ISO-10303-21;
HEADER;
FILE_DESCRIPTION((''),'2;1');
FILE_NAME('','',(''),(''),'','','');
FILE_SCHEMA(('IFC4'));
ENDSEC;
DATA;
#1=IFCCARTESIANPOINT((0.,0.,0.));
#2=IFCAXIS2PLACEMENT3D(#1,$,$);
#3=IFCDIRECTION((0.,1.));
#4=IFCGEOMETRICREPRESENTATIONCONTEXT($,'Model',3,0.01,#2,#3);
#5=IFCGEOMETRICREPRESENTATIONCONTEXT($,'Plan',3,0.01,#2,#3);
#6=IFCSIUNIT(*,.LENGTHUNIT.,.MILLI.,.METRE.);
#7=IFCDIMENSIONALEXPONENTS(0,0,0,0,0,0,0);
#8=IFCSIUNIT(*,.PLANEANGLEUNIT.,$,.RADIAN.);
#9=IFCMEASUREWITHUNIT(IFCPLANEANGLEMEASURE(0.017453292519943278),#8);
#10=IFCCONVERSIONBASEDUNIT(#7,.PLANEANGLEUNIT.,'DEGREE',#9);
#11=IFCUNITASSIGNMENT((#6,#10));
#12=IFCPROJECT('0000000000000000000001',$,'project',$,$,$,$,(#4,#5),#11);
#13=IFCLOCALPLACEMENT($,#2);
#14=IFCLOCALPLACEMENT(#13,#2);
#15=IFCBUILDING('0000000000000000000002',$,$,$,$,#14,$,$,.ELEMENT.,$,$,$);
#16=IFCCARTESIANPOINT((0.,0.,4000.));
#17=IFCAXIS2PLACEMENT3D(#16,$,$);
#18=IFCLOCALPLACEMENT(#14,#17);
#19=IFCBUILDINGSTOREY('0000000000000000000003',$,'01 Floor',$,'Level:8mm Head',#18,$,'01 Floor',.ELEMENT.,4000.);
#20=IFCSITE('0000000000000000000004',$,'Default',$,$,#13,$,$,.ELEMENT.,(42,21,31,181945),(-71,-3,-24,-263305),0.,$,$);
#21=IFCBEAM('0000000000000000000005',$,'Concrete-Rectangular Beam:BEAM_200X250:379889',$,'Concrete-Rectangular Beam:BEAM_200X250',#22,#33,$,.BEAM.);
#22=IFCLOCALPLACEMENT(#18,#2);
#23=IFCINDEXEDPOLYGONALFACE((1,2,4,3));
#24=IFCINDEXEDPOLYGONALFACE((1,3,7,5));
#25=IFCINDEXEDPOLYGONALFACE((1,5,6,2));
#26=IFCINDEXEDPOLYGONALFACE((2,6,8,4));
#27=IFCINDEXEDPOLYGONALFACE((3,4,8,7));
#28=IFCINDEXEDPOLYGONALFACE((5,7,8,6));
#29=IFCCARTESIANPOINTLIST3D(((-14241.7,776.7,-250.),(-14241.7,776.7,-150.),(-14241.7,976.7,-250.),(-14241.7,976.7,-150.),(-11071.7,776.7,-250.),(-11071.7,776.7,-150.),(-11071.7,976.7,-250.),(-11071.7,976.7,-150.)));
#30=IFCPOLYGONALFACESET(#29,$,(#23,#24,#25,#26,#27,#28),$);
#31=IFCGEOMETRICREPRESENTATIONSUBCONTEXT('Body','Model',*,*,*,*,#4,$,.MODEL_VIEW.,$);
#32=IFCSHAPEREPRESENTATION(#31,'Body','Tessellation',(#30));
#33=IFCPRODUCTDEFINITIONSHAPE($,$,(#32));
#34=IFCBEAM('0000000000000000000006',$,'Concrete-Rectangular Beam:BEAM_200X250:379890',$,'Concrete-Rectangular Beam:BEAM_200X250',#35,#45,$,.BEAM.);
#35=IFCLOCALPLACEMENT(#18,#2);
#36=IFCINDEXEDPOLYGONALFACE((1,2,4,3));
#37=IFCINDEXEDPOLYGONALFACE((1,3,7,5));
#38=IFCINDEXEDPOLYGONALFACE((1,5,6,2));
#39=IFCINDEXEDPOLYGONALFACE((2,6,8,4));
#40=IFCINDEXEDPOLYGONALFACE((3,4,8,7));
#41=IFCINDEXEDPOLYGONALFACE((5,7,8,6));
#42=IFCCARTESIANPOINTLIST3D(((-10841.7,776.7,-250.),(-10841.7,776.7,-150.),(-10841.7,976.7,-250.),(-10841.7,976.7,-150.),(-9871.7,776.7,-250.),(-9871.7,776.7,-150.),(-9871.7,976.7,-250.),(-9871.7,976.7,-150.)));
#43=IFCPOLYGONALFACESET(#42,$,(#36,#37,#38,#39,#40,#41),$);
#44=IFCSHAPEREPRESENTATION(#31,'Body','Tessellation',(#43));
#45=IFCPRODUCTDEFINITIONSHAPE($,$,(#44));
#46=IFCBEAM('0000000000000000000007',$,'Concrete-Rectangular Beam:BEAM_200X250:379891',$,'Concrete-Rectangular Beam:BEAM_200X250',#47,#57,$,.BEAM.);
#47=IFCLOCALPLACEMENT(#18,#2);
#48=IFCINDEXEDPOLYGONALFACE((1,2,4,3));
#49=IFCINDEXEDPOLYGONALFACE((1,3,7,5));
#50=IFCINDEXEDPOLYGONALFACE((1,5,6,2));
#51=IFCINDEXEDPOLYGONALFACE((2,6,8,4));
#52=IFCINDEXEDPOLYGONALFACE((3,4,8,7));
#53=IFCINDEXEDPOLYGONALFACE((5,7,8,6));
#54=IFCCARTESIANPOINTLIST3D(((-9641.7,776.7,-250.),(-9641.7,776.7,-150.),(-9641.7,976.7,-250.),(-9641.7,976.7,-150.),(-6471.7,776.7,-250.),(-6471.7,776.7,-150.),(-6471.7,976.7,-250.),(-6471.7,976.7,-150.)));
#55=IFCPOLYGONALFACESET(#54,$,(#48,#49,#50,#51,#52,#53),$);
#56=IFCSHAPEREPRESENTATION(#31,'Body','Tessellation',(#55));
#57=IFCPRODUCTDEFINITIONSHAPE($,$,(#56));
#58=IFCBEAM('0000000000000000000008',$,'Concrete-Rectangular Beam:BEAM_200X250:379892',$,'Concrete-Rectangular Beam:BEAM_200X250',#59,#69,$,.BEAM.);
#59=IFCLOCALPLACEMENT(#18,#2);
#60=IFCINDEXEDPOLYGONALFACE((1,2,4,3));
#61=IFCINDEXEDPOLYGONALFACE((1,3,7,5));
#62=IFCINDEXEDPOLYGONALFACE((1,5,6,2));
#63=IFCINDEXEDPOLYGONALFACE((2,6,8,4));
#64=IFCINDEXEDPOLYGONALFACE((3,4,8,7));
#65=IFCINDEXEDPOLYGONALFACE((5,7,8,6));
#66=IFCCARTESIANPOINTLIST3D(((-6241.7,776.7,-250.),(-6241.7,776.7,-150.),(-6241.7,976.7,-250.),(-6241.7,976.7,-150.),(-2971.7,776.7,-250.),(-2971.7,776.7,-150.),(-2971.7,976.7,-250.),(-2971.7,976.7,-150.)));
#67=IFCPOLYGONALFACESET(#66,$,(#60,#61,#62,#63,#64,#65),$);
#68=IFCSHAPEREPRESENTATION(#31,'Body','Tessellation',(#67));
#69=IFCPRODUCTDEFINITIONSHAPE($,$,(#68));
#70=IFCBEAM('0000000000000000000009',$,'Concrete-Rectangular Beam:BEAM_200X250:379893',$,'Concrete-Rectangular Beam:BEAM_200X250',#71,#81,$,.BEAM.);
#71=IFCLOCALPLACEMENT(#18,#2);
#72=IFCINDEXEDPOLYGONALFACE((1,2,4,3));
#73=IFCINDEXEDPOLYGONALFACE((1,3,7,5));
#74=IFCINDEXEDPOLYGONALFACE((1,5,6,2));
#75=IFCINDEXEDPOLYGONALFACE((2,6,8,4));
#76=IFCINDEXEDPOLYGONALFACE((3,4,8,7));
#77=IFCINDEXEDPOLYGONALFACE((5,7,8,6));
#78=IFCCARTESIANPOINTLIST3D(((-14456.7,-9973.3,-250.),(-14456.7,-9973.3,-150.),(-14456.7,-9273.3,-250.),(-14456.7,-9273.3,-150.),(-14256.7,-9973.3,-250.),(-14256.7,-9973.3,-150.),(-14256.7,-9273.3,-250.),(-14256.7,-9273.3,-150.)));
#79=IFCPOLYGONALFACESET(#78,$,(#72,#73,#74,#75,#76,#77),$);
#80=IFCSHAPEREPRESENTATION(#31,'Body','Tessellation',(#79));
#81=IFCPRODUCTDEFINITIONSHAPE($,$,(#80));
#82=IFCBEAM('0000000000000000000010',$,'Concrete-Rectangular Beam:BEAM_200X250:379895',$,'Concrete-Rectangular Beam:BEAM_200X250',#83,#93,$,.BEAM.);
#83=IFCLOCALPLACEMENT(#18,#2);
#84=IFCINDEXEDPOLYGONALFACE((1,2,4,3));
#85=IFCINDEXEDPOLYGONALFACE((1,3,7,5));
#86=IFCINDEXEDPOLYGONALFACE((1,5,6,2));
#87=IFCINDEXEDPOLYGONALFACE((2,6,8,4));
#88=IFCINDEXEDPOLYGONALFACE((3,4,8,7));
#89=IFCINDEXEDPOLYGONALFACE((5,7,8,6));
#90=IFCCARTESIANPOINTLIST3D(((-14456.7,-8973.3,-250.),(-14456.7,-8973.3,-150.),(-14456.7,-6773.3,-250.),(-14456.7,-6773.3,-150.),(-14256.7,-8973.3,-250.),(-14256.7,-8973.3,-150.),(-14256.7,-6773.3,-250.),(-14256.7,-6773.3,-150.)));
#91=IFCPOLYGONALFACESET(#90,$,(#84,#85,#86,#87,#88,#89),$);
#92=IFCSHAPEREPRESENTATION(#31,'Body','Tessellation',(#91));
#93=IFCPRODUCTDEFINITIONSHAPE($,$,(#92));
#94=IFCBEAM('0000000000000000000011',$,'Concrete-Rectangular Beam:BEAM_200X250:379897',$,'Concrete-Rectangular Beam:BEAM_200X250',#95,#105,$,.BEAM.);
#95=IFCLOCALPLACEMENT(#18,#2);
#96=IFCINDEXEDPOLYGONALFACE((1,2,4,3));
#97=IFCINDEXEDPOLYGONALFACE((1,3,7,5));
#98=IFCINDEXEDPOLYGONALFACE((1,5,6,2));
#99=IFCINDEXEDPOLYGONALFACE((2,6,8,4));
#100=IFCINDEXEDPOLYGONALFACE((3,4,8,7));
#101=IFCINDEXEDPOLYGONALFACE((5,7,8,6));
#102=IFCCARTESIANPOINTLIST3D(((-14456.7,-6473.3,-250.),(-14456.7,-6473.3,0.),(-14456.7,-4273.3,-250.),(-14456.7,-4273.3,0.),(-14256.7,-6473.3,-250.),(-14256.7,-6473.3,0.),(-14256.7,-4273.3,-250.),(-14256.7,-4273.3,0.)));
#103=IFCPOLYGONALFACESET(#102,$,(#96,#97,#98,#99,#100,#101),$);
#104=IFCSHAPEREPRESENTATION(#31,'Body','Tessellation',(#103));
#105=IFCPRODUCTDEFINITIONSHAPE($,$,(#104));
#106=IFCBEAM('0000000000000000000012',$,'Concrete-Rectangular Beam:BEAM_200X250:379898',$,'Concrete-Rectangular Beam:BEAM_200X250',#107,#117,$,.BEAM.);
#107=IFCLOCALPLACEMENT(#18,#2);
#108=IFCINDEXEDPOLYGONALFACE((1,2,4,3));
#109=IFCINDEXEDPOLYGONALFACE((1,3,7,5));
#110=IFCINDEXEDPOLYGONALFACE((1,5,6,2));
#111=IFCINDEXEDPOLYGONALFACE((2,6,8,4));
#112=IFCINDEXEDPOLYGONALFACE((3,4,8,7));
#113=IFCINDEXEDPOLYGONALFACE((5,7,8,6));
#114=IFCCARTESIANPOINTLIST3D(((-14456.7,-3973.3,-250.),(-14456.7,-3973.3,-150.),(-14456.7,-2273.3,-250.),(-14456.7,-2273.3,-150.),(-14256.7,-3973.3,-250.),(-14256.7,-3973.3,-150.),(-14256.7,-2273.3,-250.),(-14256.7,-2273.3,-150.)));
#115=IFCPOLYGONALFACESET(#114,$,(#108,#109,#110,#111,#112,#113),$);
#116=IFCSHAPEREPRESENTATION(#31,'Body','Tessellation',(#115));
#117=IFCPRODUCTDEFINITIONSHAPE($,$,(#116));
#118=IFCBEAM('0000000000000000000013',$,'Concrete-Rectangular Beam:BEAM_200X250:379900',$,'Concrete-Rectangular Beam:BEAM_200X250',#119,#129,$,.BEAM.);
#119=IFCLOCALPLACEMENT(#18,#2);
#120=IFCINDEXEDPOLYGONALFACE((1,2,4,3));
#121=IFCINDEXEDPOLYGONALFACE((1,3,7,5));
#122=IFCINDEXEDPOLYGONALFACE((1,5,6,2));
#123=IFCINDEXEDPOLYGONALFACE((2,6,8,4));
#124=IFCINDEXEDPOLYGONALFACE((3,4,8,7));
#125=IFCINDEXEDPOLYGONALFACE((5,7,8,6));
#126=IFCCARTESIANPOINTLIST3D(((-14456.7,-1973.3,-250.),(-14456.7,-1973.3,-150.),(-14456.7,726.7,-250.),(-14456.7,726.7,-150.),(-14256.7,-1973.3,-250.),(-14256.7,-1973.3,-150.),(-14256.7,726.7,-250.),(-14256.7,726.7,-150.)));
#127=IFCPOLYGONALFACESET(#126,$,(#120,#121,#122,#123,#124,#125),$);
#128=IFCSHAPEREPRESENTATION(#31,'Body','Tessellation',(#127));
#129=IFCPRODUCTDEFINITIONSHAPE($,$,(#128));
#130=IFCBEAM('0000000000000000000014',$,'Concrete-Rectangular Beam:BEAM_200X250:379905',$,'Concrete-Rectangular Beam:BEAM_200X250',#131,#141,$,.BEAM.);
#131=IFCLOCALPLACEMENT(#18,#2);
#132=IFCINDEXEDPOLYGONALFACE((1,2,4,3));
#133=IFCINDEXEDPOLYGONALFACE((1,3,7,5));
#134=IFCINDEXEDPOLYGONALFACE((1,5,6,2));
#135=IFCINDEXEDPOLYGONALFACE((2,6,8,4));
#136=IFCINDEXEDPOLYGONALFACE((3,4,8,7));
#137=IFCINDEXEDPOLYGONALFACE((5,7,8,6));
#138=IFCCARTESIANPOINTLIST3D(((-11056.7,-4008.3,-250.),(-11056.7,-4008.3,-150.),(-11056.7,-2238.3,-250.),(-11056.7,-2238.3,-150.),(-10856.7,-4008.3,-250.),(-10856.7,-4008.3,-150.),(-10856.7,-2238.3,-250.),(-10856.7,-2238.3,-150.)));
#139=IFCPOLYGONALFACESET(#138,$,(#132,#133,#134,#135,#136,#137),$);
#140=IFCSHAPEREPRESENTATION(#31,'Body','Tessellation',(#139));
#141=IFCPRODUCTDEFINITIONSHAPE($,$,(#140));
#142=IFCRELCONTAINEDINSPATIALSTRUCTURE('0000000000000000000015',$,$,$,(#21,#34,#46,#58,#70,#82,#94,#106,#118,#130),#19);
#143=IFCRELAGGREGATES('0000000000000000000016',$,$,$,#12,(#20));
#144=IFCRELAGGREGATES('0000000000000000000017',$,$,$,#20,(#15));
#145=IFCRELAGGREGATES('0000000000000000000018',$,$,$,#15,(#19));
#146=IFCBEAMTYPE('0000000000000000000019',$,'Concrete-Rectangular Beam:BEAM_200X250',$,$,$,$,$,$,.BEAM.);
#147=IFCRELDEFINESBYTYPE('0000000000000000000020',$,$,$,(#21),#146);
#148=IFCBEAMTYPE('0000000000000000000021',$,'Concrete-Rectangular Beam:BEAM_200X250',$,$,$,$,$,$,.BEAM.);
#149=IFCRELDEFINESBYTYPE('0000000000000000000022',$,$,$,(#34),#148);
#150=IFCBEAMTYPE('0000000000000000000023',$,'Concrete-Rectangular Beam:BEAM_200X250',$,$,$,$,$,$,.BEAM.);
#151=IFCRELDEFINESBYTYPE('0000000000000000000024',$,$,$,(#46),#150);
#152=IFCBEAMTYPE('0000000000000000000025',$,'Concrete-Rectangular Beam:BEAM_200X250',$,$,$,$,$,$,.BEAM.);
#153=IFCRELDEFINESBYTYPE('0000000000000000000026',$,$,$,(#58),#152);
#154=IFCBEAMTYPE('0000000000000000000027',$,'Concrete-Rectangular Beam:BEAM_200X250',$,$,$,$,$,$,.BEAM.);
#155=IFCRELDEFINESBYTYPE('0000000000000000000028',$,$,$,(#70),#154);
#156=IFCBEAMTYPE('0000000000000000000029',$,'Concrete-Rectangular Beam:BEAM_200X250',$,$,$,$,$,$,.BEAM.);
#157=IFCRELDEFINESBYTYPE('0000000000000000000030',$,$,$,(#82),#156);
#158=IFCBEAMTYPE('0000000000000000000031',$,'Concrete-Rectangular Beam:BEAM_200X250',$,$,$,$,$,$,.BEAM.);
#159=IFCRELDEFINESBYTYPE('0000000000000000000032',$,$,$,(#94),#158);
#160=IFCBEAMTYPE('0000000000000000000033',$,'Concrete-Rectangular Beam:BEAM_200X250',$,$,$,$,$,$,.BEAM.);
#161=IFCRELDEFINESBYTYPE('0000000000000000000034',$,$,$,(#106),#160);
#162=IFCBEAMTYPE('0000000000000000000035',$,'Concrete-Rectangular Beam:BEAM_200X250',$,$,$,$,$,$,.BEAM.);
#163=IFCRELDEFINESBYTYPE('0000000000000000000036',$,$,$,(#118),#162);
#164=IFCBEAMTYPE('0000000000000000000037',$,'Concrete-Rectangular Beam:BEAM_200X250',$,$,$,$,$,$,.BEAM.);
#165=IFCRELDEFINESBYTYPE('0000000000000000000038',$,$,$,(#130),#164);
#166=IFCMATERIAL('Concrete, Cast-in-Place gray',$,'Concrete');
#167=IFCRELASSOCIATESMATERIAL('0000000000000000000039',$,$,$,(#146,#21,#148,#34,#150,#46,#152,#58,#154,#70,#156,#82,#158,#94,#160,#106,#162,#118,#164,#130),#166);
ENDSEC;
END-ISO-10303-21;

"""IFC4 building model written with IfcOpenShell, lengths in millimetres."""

from ifc_helpers import new_model, entity, si_unit, converted_unit, direction, frame, origin, place, context, subcontext, project, spatial, indexed_curve, outline, extrude, source, transform, mapped, material, type_object, type_shapes, element, save


model = new_model("IFC4")

# Units and contexts
model_context = context("Model", 3, precision=0.01, world=origin(), true_north=direction((0.0, 1.0)))
plan_context = context("Plan", 3, precision=0.01, world=origin(), true_north=direction((0.0, 1.0)))
body_context = subcontext(model_context, "Body", "Model", "MODEL_VIEW")
ifc_project = project(units=[si_unit("LENGTHUNIT", "METRE", prefix="MILLI"), converted_unit("PLANEANGLEUNIT", "DEGREE", entity("IfcPlaneAngleMeasure", 0.017453292519943278), si_unit("PLANEANGLEUNIT", "RADIAN"), dimensions=[0, 0, 0, 0, 0, 0, 0])], contexts=[model_context, plan_context])

# Site, building, storey
site_placement = place(None, origin())
site = spatial("IfcSite", under=ifc_project, at=site_placement, Name="Default", CompositionType="ELEMENT", RefLatitude=(42, 21, 31, 181945), RefLongitude=(-71, -3, -24, -263305), RefElevation=0.0)
building_placement = place(site_placement, origin())
building = spatial("IfcBuilding", under=site, at=building_placement, CompositionType="ELEMENT")
storey_placement = place(building_placement, frame((0.0, 0.0, 4000.0)))
storey = spatial("IfcBuildingStorey", under=building, at=storey_placement, Name="01 Floor", ObjectType="Level:8mm Head", LongName="01 Floor", CompositionType="ELEMENT", Elevation=4000.0)

# Beams
ifc_material = material(Name="Concrete, Cast-in-Place gray", Category="Concrete")
beam_type_1 = type_object("IfcBeamType", Name="Concrete-Rectangular Beam:BEAM_200X250", PredefinedType="BEAM", material=ifc_material)
shared_shape_1 = source(origin(), body_context, "Body", "SweptSolid", [
    extrude(outline(indexed_curve([(-50.0, -100.0), (50.0, -100.0), (50.0, 100.0), (-50.0, 100.0), (-50.0, -100.0)], self_intersect=False)), frame((-14241.7, 876.7, 3800.0), z_axis=(1.0, 0.0, 0.0), x_axis=(0.0, 0.0, -1.0)), (0.0, 0.0, 1.0), 3170.0),
])
type_shapes(beam_type_1, [shared_shape_1])
beam_1_placement = place(storey_placement, frame((0.0, 0.0, -4000.0)))
element("IfcBeam", 1, at=beam_1_placement, inside=storey, type_object=beam_type_1, material=ifc_material, Name="Concrete-Rectangular Beam:BEAM_200X250:379889", ObjectType="Concrete-Rectangular Beam:BEAM_200X250", PredefinedType="BEAM", context=body_context, shape_type="MappedRepresentation", body=[
    mapped(shared_shape_1, transform((0.0, 0.0, 0.0), scale=1.0)),
])
beam_type_2 = type_object("IfcBeamType", Name="Concrete-Rectangular Beam:BEAM_200X250", PredefinedType="BEAM", material=ifc_material)
shared_shape_2 = source(origin(), body_context, "Body", "SweptSolid", [
    extrude(outline(indexed_curve([(-50.0, -100.0), (50.0, -100.0), (50.0, 100.0), (-50.0, 100.0), (-50.0, -100.0)], self_intersect=False)), frame((-10841.7, 876.7, 3800.0), z_axis=(1.0, 0.0, 0.0), x_axis=(0.0, 0.0, -1.0)), (0.0, 0.0, 1.0), 970.0),
])
type_shapes(beam_type_2, [shared_shape_2])
beam_2_placement = place(storey_placement, frame((0.0, 0.0, -4000.0)))
element("IfcBeam", 2, at=beam_2_placement, inside=storey, type_object=beam_type_2, material=ifc_material, Name="Concrete-Rectangular Beam:BEAM_200X250:379890", ObjectType="Concrete-Rectangular Beam:BEAM_200X250", PredefinedType="BEAM", context=body_context, shape_type="MappedRepresentation", body=[
    mapped(shared_shape_2, transform((0.0, 0.0, 0.0), scale=1.0)),
])
beam_type_3 = type_object("IfcBeamType", Name="Concrete-Rectangular Beam:BEAM_200X250", PredefinedType="BEAM", material=ifc_material)
shared_shape_3 = source(origin(), body_context, "Body", "SweptSolid", [
    extrude(outline(indexed_curve([(-50.0, -100.0), (50.0, -100.0), (50.0, 100.0), (-50.0, 100.0), (-50.0, -100.0)], self_intersect=False)), frame((-9641.7, 876.7, 3800.0), z_axis=(1.0, 0.0, 0.0), x_axis=(0.0, 0.0, -1.0)), (0.0, 0.0, 1.0), 3170.0),
])
type_shapes(beam_type_3, [shared_shape_3])
beam_3_placement = place(storey_placement, frame((0.0, 0.0, -4000.0)))
element("IfcBeam", 3, at=beam_3_placement, inside=storey, type_object=beam_type_3, material=ifc_material, Name="Concrete-Rectangular Beam:BEAM_200X250:379891", ObjectType="Concrete-Rectangular Beam:BEAM_200X250", PredefinedType="BEAM", context=body_context, shape_type="MappedRepresentation", body=[
    mapped(shared_shape_3, transform((0.0, 0.0, 0.0), scale=1.0)),
])
beam_type_4 = type_object("IfcBeamType", Name="Concrete-Rectangular Beam:BEAM_200X250", PredefinedType="BEAM", material=ifc_material)
shared_shape_4 = source(origin(), body_context, "Body", "SweptSolid", [
    extrude(outline(indexed_curve([(-50.0, -100.0), (50.0, -100.0), (50.0, 100.0), (-50.0, 100.0), (-50.0, -100.0)], self_intersect=False)), frame((-6241.7, 876.7, 3800.0), z_axis=(1.0, 0.0, 0.0), x_axis=(0.0, 0.0, -1.0)), (0.0, 0.0, 1.0), 3270.0),
])
type_shapes(beam_type_4, [shared_shape_4])
beam_4_placement = place(storey_placement, frame((0.0, 0.0, -4000.0)))
element("IfcBeam", 4, at=beam_4_placement, inside=storey, type_object=beam_type_4, material=ifc_material, Name="Concrete-Rectangular Beam:BEAM_200X250:379892", ObjectType="Concrete-Rectangular Beam:BEAM_200X250", PredefinedType="BEAM", context=body_context, shape_type="MappedRepresentation", body=[
    mapped(shared_shape_4, transform((0.0, 0.0, 0.0), scale=1.0)),
])
beam_type_5 = type_object("IfcBeamType", Name="Concrete-Rectangular Beam:BEAM_200X250", PredefinedType="BEAM", material=ifc_material)
shared_shape_5 = source(origin(), body_context, "Body", "SweptSolid", [
    extrude(outline(indexed_curve([(-100.0, -50.0), (100.0, -50.0), (100.0, 50.0), (-100.0, 50.0), (-100.0, -50.0)], self_intersect=False)), frame((-14356.7, -9973.3, 3800.0), z_axis=(0.0, 1.0, 0.0), x_axis=(-1.0, 0.0, 0.0)), (0.0, 0.0, 1.0), 700.0),
])
type_shapes(beam_type_5, [shared_shape_5])
beam_5_placement = place(storey_placement, frame((0.0, 0.0, -4000.0)))
element("IfcBeam", 5, at=beam_5_placement, inside=storey, type_object=beam_type_5, material=ifc_material, Name="Concrete-Rectangular Beam:BEAM_200X250:379893", ObjectType="Concrete-Rectangular Beam:BEAM_200X250", PredefinedType="BEAM", context=body_context, shape_type="MappedRepresentation", body=[
    mapped(shared_shape_5, transform((0.0, 0.0, 0.0), scale=1.0)),
])
beam_type_6 = type_object("IfcBeamType", Name="Concrete-Rectangular Beam:BEAM_200X250", PredefinedType="BEAM", material=ifc_material)
shared_shape_6 = source(origin(), body_context, "Body", "SweptSolid", [
    extrude(outline(indexed_curve([(-100.0, -50.0), (100.0, -50.0), (100.0, 50.0), (-100.0, 50.0), (-100.0, -50.0)], self_intersect=False)), frame((-14356.7, -8973.3, 3800.0), z_axis=(0.0, 1.0, 0.0), x_axis=(-1.0, 0.0, 0.0)), (0.0, 0.0, 1.0), 2200.0),
])
type_shapes(beam_type_6, [shared_shape_6])
beam_6_placement = place(storey_placement, frame((0.0, 0.0, -4000.0)))
element("IfcBeam", 6, at=beam_6_placement, inside=storey, type_object=beam_type_6, material=ifc_material, Name="Concrete-Rectangular Beam:BEAM_200X250:379895", ObjectType="Concrete-Rectangular Beam:BEAM_200X250", PredefinedType="BEAM", context=body_context, shape_type="MappedRepresentation", body=[
    mapped(shared_shape_6, transform((0.0, 0.0, 0.0), scale=1.0)),
])
beam_type_7 = type_object("IfcBeamType", Name="Concrete-Rectangular Beam:BEAM_200X250", PredefinedType="BEAM", material=ifc_material)
shared_shape_7 = source(origin(), body_context, "Body", "SweptSolid", [
    extrude(outline(indexed_curve([(-100.0, -125.0), (100.0, -125.0), (100.0, 125.0), (-100.0, 125.0), (-100.0, -125.0)], self_intersect=False)), frame((-14356.7, -6473.3, 3875.0), z_axis=(0.0, 1.0, 0.0), x_axis=(-1.0, 0.0, 0.0)), (0.0, 0.0, 1.0), 2200.0),
])
type_shapes(beam_type_7, [shared_shape_7])
beam_7_placement = place(storey_placement, frame((0.0, 0.0, -4000.0)))
element("IfcBeam", 7, at=beam_7_placement, inside=storey, type_object=beam_type_7, material=ifc_material, Name="Concrete-Rectangular Beam:BEAM_200X250:379897", ObjectType="Concrete-Rectangular Beam:BEAM_200X250", PredefinedType="BEAM", context=body_context, shape_type="MappedRepresentation", body=[
    mapped(shared_shape_7, transform((0.0, 0.0, 0.0), scale=1.0)),
])
beam_type_8 = type_object("IfcBeamType", Name="Concrete-Rectangular Beam:BEAM_200X250", PredefinedType="BEAM", material=ifc_material)
shared_shape_8 = source(origin(), body_context, "Body", "SweptSolid", [
    extrude(outline(indexed_curve([(-100.0, -50.0), (100.0, -50.0), (100.0, 50.0), (-100.0, 50.0), (-100.0, -50.0)], self_intersect=False)), frame((-14356.7, -3973.3, 3800.0), z_axis=(0.0, 1.0, 0.0), x_axis=(-1.0, 0.0, 0.0)), (0.0, 0.0, 1.0), 1700.0),
])
type_shapes(beam_type_8, [shared_shape_8])
beam_8_placement = place(storey_placement, frame((0.0, 0.0, -4000.0)))
element("IfcBeam", 8, at=beam_8_placement, inside=storey, type_object=beam_type_8, material=ifc_material, Name="Concrete-Rectangular Beam:BEAM_200X250:379898", ObjectType="Concrete-Rectangular Beam:BEAM_200X250", PredefinedType="BEAM", context=body_context, shape_type="MappedRepresentation", body=[
    mapped(shared_shape_8, transform((0.0, 0.0, 0.0), scale=1.0)),
])
beam_type_9 = type_object("IfcBeamType", Name="Concrete-Rectangular Beam:BEAM_200X250", PredefinedType="BEAM", material=ifc_material)
shared_shape_9 = source(origin(), body_context, "Body", "SweptSolid", [
    extrude(outline(indexed_curve([(-100.0, -50.0), (100.0, -50.0), (100.0, 50.0), (-100.0, 50.0), (-100.0, -50.0)], self_intersect=False)), frame((-14356.7, -1973.3, 3800.0), z_axis=(0.0, 1.0, 0.0), x_axis=(-1.0, 0.0, 0.0)), (0.0, 0.0, 1.0), 2700.0),
])
type_shapes(beam_type_9, [shared_shape_9])
beam_9_placement = place(storey_placement, frame((0.0, 0.0, -4000.0)))
element("IfcBeam", 9, at=beam_9_placement, inside=storey, type_object=beam_type_9, material=ifc_material, Name="Concrete-Rectangular Beam:BEAM_200X250:379900", ObjectType="Concrete-Rectangular Beam:BEAM_200X250", PredefinedType="BEAM", context=body_context, shape_type="MappedRepresentation", body=[
    mapped(shared_shape_9, transform((0.0, 0.0, 0.0), scale=1.0)),
])
beam_type_10 = type_object("IfcBeamType", Name="Concrete-Rectangular Beam:BEAM_200X250", PredefinedType="BEAM", material=ifc_material)
shared_shape_10 = source(origin(), body_context, "Body", "SweptSolid", [
    extrude(outline(indexed_curve([(-100.0, -50.0), (100.0, -50.0), (100.0, 50.0), (-100.0, 50.0), (-100.0, -50.0)], self_intersect=False)), frame((-10956.7, -4008.3, 3800.0), z_axis=(0.0, 1.0, 0.0), x_axis=(-1.0, 0.0, 0.0)), (0.0, 0.0, 1.0), 1770.0),
])
type_shapes(beam_type_10, [shared_shape_10])
beam_10_placement = place(storey_placement, frame((0.0, 0.0, -4000.0)))
element("IfcBeam", 10, at=beam_10_placement, inside=storey, type_object=beam_type_10, material=ifc_material, Name="Concrete-Rectangular Beam:BEAM_200X250:379905", ObjectType="Concrete-Rectangular Beam:BEAM_200X250", PredefinedType="BEAM", context=body_context, shape_type="MappedRepresentation", body=[
    mapped(shared_shape_10, transform((0.0, 0.0, 0.0), scale=1.0)),
])

save(model, "model.ifc")
